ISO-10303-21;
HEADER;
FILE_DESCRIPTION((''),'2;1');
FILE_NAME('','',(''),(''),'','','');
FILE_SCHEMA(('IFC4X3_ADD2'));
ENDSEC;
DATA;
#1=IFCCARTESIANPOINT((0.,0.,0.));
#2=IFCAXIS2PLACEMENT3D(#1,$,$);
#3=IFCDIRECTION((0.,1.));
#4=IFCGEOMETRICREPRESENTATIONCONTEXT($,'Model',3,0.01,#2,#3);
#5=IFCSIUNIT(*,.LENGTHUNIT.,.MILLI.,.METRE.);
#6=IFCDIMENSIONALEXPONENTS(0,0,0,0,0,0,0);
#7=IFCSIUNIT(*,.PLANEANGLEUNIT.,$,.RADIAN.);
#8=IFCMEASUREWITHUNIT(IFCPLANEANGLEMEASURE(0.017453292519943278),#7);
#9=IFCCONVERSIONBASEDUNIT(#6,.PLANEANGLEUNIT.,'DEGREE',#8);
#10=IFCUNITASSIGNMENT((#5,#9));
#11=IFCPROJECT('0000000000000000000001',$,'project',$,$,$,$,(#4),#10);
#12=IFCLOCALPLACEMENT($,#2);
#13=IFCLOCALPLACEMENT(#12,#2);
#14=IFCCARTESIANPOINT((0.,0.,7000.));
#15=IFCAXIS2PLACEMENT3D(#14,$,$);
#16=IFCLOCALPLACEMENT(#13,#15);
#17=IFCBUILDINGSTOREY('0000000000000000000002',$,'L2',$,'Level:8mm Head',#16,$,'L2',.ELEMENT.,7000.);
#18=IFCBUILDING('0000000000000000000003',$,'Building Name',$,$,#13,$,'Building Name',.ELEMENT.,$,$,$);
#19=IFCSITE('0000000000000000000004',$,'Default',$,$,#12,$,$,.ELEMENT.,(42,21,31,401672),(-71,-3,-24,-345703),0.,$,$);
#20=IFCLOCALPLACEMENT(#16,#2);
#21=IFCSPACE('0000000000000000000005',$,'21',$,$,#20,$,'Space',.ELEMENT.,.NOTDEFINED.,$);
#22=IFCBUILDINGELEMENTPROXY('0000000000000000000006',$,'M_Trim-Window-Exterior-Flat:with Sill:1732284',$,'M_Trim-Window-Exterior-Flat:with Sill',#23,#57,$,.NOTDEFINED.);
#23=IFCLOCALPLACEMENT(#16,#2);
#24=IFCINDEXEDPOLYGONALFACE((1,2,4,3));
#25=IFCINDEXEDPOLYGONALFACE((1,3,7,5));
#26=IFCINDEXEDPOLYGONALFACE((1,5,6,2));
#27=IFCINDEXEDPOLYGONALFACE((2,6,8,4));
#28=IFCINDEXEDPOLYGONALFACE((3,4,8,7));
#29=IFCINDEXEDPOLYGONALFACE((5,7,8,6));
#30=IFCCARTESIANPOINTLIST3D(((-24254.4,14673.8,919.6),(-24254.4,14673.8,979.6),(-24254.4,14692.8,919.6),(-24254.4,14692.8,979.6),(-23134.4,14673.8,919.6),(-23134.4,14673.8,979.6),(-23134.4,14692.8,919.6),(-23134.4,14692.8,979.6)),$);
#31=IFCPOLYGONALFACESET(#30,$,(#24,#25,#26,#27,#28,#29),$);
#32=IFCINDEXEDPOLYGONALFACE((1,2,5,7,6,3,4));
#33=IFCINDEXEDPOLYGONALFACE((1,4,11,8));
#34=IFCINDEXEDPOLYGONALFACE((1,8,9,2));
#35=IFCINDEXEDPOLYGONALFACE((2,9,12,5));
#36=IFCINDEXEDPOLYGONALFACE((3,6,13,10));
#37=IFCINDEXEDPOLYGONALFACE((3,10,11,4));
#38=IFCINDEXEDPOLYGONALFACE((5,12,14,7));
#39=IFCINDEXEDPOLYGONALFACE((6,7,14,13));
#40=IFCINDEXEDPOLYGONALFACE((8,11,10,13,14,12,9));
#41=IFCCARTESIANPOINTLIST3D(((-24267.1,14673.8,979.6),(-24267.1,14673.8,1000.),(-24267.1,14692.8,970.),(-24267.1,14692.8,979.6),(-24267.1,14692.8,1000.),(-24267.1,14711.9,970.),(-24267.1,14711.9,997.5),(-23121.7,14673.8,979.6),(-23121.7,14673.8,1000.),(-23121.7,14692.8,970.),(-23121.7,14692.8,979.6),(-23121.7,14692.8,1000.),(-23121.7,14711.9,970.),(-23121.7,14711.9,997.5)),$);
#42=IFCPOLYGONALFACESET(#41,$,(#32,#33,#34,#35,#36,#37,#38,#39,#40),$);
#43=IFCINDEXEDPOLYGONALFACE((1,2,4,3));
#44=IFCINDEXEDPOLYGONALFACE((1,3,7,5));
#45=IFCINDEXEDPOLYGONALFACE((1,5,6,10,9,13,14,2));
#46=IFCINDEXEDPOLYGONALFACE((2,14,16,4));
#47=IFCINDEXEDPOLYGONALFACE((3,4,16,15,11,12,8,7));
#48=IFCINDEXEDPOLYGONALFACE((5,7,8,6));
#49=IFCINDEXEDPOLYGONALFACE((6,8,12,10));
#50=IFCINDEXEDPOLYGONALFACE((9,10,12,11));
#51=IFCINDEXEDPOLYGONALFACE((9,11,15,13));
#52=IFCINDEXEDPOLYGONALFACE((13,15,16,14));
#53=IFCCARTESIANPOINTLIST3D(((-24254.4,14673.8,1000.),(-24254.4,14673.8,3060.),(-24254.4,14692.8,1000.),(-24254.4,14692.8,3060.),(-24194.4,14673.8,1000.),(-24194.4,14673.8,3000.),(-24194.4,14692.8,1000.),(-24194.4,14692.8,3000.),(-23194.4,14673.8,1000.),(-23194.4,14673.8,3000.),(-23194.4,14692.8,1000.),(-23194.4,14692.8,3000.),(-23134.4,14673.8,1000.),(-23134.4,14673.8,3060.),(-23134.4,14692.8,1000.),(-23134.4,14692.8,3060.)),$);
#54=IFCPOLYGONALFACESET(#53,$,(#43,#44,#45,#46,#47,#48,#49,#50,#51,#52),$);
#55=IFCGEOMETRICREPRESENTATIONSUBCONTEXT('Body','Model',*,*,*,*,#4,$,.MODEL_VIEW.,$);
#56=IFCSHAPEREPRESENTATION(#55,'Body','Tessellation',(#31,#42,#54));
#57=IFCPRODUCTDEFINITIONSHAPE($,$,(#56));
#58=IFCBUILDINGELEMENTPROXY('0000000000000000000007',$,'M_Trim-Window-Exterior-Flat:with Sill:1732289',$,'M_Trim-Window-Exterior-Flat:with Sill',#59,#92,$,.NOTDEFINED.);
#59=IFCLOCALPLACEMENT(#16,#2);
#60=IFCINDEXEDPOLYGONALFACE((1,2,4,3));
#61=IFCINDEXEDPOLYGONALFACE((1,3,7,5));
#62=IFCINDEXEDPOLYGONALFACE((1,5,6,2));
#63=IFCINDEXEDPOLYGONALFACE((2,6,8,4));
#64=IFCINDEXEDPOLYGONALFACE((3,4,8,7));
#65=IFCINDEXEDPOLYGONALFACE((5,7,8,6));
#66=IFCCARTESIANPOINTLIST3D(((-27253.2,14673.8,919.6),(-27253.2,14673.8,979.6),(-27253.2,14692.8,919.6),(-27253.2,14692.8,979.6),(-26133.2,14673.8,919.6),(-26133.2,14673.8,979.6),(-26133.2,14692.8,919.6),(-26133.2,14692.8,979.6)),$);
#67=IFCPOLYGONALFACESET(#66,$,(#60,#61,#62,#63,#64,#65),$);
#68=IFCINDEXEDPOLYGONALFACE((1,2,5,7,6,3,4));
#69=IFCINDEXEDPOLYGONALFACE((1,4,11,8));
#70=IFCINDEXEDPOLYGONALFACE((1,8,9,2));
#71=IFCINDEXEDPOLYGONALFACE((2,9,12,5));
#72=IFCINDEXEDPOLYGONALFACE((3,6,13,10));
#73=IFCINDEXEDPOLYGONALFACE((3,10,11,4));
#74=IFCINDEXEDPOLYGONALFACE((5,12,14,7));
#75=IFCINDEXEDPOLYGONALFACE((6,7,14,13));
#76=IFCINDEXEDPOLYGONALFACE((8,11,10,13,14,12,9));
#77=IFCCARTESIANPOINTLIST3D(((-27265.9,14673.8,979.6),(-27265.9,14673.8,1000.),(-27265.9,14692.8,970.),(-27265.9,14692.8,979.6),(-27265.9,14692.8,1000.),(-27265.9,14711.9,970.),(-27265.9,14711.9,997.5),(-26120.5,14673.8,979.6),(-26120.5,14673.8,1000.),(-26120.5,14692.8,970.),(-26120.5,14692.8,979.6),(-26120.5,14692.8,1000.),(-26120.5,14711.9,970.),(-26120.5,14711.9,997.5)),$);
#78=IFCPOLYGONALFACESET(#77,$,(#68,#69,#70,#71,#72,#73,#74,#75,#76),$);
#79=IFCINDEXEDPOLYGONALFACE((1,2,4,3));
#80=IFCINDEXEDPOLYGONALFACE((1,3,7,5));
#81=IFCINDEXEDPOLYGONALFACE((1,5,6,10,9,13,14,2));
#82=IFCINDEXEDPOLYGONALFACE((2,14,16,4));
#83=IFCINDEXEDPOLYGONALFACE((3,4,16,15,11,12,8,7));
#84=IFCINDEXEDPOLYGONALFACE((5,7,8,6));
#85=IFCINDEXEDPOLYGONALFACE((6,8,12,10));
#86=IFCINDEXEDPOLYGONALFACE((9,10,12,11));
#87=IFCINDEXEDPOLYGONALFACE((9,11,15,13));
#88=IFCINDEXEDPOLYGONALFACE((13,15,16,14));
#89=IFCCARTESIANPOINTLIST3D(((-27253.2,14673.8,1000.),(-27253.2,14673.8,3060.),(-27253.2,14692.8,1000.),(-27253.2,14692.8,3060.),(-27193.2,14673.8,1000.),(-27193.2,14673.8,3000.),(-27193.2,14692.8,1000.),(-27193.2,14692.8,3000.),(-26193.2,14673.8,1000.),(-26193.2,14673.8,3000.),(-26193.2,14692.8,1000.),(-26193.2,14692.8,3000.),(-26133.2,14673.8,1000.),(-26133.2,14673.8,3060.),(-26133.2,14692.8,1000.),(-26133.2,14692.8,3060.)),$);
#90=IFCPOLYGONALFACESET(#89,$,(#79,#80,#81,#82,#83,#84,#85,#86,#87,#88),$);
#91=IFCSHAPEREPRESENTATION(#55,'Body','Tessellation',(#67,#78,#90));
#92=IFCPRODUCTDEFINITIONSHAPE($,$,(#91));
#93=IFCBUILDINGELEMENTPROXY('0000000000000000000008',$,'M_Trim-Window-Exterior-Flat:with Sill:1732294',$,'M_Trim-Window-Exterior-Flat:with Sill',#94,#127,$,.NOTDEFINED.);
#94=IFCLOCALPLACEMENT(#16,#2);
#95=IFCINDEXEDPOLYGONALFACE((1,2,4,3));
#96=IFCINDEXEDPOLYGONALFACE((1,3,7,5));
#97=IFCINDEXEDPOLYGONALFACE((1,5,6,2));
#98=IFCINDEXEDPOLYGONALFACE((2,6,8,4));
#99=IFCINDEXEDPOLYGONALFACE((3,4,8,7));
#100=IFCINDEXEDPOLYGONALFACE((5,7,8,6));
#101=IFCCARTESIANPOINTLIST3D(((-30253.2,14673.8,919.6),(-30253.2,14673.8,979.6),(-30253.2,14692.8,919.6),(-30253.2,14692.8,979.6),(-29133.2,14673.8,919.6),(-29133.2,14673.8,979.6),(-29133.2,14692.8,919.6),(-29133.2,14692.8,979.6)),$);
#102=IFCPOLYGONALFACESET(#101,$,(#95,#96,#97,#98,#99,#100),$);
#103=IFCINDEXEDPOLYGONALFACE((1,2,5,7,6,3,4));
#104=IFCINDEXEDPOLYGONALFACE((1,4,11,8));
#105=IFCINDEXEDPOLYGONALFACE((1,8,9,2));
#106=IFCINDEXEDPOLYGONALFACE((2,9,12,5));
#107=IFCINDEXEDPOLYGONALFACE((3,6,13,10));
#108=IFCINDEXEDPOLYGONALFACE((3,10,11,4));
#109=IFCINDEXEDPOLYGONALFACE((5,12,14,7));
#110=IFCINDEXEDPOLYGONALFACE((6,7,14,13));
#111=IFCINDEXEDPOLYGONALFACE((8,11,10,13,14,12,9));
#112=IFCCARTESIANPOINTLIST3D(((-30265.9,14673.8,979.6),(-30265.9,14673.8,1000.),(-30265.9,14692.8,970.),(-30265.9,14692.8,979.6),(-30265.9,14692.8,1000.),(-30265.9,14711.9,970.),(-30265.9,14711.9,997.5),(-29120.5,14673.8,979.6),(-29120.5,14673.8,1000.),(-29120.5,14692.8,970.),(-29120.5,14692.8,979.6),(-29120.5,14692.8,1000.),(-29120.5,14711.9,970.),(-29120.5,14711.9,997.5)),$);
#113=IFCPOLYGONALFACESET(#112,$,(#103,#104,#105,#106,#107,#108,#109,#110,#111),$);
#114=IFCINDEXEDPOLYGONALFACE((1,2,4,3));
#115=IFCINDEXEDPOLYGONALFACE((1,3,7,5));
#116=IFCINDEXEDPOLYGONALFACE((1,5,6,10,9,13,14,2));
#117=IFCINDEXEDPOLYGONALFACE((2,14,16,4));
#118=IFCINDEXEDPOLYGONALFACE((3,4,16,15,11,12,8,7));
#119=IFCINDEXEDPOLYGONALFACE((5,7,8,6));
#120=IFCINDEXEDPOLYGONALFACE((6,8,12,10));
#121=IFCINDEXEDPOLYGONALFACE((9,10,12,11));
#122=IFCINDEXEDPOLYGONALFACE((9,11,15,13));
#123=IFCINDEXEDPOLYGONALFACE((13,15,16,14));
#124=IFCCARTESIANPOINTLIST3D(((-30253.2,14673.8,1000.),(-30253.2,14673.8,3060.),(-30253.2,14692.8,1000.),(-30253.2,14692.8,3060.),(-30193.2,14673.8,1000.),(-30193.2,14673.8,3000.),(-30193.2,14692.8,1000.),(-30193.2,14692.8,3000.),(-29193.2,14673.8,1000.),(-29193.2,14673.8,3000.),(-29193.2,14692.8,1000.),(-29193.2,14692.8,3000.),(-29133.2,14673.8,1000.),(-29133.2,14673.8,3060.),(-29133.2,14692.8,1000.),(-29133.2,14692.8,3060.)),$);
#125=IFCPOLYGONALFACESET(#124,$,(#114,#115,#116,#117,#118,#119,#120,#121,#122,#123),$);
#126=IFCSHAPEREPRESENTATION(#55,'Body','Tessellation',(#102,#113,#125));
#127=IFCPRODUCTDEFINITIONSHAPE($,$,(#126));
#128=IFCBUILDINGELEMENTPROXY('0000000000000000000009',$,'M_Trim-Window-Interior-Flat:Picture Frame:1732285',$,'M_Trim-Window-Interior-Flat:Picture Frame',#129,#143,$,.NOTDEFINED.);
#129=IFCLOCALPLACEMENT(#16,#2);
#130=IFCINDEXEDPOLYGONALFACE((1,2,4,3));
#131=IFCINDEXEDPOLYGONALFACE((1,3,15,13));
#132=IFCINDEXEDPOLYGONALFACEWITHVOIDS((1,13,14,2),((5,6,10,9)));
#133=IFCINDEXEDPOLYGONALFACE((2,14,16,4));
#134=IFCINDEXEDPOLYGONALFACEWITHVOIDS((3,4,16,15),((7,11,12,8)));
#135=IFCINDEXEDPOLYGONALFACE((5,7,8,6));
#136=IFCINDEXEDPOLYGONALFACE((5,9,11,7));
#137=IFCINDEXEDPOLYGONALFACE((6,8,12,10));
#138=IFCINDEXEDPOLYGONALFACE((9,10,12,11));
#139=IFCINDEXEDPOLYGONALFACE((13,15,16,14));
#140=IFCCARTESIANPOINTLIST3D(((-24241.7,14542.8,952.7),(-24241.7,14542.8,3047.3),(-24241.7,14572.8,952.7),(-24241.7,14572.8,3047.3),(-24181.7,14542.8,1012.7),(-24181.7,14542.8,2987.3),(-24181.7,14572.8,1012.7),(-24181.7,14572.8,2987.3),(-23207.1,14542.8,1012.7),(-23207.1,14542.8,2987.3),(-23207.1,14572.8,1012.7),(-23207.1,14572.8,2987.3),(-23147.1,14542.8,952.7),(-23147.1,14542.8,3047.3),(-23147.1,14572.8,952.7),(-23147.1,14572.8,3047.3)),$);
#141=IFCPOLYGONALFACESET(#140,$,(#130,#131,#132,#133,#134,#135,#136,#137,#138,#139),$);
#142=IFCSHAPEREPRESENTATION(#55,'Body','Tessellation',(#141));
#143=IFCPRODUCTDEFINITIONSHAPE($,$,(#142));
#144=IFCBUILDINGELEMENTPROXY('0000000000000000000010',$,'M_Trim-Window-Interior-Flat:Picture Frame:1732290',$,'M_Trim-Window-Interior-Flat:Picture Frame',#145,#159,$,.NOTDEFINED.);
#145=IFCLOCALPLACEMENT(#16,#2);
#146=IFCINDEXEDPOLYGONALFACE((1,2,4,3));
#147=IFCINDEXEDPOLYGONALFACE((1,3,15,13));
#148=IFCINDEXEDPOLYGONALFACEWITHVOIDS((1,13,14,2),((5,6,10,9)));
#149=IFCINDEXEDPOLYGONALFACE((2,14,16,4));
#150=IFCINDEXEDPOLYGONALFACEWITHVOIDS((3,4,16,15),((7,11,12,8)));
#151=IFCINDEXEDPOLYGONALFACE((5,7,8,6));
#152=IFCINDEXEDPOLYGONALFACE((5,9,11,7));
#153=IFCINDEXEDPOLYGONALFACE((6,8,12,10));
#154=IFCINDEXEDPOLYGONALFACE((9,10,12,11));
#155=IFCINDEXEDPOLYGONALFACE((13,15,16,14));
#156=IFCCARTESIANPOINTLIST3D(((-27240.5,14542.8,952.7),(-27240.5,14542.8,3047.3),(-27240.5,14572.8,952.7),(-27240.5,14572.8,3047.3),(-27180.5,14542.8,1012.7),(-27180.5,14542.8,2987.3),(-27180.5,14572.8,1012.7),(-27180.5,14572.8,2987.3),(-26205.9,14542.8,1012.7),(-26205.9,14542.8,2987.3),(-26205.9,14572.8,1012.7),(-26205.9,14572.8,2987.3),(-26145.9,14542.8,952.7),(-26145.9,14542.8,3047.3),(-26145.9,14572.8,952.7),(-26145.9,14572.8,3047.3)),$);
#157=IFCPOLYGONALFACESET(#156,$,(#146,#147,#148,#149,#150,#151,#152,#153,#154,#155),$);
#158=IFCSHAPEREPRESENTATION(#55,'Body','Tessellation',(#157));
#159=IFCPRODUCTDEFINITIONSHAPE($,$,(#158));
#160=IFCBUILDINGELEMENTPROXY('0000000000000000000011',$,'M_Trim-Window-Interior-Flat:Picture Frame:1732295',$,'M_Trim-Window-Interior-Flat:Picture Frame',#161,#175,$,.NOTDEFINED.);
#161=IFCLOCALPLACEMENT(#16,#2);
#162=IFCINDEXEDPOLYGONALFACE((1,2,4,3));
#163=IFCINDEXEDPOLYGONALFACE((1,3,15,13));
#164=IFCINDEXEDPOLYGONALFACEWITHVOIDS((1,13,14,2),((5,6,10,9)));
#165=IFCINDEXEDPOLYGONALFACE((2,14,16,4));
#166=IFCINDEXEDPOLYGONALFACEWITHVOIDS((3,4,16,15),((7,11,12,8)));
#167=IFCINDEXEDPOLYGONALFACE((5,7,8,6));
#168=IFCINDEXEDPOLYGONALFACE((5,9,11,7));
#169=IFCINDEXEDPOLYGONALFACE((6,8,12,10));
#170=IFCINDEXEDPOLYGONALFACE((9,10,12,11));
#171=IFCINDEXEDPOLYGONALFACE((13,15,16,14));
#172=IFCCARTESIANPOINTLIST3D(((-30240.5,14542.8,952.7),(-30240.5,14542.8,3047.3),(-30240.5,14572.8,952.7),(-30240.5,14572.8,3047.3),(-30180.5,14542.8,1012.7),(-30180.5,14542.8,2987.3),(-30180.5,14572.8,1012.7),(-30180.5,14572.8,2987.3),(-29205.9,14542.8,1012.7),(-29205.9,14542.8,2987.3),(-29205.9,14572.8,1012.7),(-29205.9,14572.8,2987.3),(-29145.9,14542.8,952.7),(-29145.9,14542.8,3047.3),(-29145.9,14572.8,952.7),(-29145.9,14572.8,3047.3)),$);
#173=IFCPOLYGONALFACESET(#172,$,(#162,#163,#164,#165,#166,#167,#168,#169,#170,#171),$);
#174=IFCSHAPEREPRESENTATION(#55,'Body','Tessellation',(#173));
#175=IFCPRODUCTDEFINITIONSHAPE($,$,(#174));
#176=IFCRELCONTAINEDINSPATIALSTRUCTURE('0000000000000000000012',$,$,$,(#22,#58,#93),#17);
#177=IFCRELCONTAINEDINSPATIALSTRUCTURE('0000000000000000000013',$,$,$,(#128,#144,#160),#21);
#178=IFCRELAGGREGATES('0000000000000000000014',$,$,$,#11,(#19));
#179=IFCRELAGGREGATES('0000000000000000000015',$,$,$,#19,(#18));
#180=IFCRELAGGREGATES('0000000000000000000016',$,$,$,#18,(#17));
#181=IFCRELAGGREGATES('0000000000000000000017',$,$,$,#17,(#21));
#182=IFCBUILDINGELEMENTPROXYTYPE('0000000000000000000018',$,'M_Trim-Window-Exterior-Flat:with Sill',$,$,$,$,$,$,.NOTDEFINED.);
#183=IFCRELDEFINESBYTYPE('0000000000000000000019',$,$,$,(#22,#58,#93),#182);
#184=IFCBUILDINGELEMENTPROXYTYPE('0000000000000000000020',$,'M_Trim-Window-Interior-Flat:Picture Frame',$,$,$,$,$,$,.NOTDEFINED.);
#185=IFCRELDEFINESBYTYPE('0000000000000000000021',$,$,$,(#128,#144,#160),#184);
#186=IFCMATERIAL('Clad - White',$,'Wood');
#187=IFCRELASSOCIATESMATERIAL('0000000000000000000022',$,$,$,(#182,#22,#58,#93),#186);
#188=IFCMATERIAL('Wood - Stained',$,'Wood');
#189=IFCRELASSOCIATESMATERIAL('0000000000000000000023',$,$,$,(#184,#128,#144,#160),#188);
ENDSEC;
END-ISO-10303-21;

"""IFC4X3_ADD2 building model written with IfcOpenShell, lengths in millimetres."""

from ifc_helpers import new_model, entity, si_unit, converted_unit, direction, frame, frame_2d, origin, place, context, subcontext, project, spatial, polyline, rectangle, outline, extrude, source, transform, mapped, material, type_object, type_shapes, element, save


model = new_model("IFC4X3_ADD2")

# Units and contexts
model_context = context("Model", 3, precision=0.01, world=origin(), true_north=direction((0.0, 1.0)))
body_context = subcontext(model_context, "Body", "Model", "MODEL_VIEW")
ifc_project = project(units=[si_unit("LENGTHUNIT", "METRE", prefix="MILLI"), converted_unit("PLANEANGLEUNIT", "DEGREE", entity("IfcPlaneAngleMeasure", 0.017453292519943278), si_unit("PLANEANGLEUNIT", "RADIAN"), dimensions=[0, 0, 0, 0, 0, 0, 0])], contexts=[model_context])

# Site, building, storey
site_placement = place(None, origin())
site = spatial("IfcSite", under=ifc_project, at=site_placement, Name="Default", CompositionType="ELEMENT", RefLatitude=(42, 21, 31, 401672), RefLongitude=(-71, -3, -24, -345703), RefElevation=0.0)
building_placement = place(site_placement, origin())
building = spatial("IfcBuilding", under=site, at=building_placement, Name="Building Name", LongName="Building Name", CompositionType="ELEMENT")
storey_placement = place(building_placement, frame((0.0, 0.0, 7000.0)))
storey = spatial("IfcBuildingStorey", under=building, at=storey_placement, Name="L2", ObjectType="Level:8mm Head", LongName="L2", CompositionType="ELEMENT", Elevation=7000.0)

# Building element proxies
ifc_material_1 = material(Name="Clad - White", Category="Wood")
ifc_material_2 = material(Name="Wood - Stained", Category="Wood")
building_element_proxy_type_1 = type_object("IfcBuildingElementProxyType", Name="M_Trim-Window-Exterior-Flat:with Sill", PredefinedType="NOTDEFINED", material=ifc_material_1)
shared_shape_1 = source(origin(), body_context, "Body", "SweptSolid", [
    extrude(rectangle(XDim=1120.0, YDim=60.0, at=frame_2d((0.0, 0.0), x_axis=(1.0, 0.0))), frame((0.0, -2050.4, 0.0), z_axis=(0.0, 0.0, 1.0), x_axis=(-1.0, 0.0, 0.0)), (0.0, 0.0, 1.0), 19.0),
    extrude(outline(polyline([(-19.0, -15.2), (0.0, -15.2), (0.0, -5.7), (19.0, -5.7), (19.0, 14.8), (0.0, 14.8), (-19.0, 12.3), (-19.0, -15.2)])), frame((-572.7, -2014.8, 19.0), z_axis=(1.0, 0.0, 0.0), x_axis=(0.0, 0.0, -1.0)), (0.0, 0.0, 1.0), 1145.4),
    extrude(outline(polyline([(-1045.0, -560.0), (1015.0, -560.0), (1015.0, -500.0), (-985.0, -500.0), (-985.0, 500.0), (1015.0, 500.0), (1015.0, 560.0), (-1045.0, 560.0), (-1045.0, -560.0)])), frame((0.0, -985.0, 0.0), z_axis=(0.0, 0.0, 1.0), x_axis=(0.0, -1.0, 0.0)), (0.0, 0.0, 1.0), 19.0),
])
type_shapes(building_element_proxy_type_1, [shared_shape_1])
for number, where, z_axis, x_axis, name in (
    (1, (-23694.4, 14673.8, 3000.0), (0.0, 1.0, 0.0), (-1.0, 0.0, 0.0), "M_Trim-Window-Exterior-Flat:with Sill:1732284"),
    (2, (-26693.2, 14673.8, 3000.0), (0.0, 1.0, 0.0), (-1.0, 0.0, 0.0), "M_Trim-Window-Exterior-Flat:with Sill:1732289"),
    (3, (-29693.2, 14673.8, 3000.0), (0.0, 1.0, 0.0), (-1.0, 0.0, 0.0), "M_Trim-Window-Exterior-Flat:with Sill:1732294"),
):
    element("IfcBuildingElementProxy", number, at=place(storey_placement, frame(where, z_axis=z_axis, x_axis=x_axis)), inside=storey, type_object=building_element_proxy_type_1, material=ifc_material_1, Name=name, ObjectType="M_Trim-Window-Exterior-Flat:with Sill", PredefinedType="NOTDEFINED", context=body_context, shape_type="MappedRepresentation", body=[
        mapped(shared_shape_1, transform((0.0, 0.0, 0.0), scale=1.0)),
    ])

# Shared definitions
space_placement = place(storey_placement, origin())
space = spatial("IfcSpace", under=storey, at=space_placement, Name="21", LongName="Space", CompositionType="ELEMENT", PredefinedType="NOTDEFINED")

# Building element proxies
building_element_proxy_type_2 = type_object("IfcBuildingElementProxyType", Name="M_Trim-Window-Interior-Flat:Picture Frame", PredefinedType="NOTDEFINED", material=ifc_material_2)
shared_shape_2 = source(origin(), body_context, "Body", "SweptSolid", [
    extrude(outline(polyline([(-547.3, -1047.3), (547.3, -1047.3), (547.3, 1047.3), (-547.3, 1047.3), (-547.3, -1047.3)]), holes=[polyline([(-487.3, -987.3), (-487.3, 987.3), (487.3, 987.3), (487.3, -987.3), (-487.3, -987.3)])]), frame((0.0, -1000.0, 0.0), z_axis=(0.0, 0.0, 1.0), x_axis=(-1.0, 0.0, 0.0)), (0.0, 0.0, 1.0), 30.0),
])
type_shapes(building_element_proxy_type_2, [shared_shape_2])
for number, where, z_axis, x_axis, name in (
    (4, (-23694.4, 14572.8, 3000.0), (0.0, -1.0, 0.0), (1.0, 0.0, 0.0), "M_Trim-Window-Interior-Flat:Picture Frame:1732285"),
    (5, (-26693.2, 14572.8, 3000.0), (0.0, -1.0, 0.0), (1.0, 0.0, 0.0), "M_Trim-Window-Interior-Flat:Picture Frame:1732290"),
    (6, (-29693.2, 14572.8, 3000.0), (0.0, -1.0, 0.0), (1.0, 0.0, 0.0), "M_Trim-Window-Interior-Flat:Picture Frame:1732295"),
):
    element("IfcBuildingElementProxy", number, at=place(space_placement, frame(where, z_axis=z_axis, x_axis=x_axis)), inside=space, type_object=building_element_proxy_type_2, material=ifc_material_2, Name=name, ObjectType="M_Trim-Window-Interior-Flat:Picture Frame", PredefinedType="NOTDEFINED", context=body_context, shape_type="MappedRepresentation", body=[
        mapped(shared_shape_2, transform((0.0, 0.0, 0.0), scale=1.0)),
    ])

save(model, "model.ifc")
